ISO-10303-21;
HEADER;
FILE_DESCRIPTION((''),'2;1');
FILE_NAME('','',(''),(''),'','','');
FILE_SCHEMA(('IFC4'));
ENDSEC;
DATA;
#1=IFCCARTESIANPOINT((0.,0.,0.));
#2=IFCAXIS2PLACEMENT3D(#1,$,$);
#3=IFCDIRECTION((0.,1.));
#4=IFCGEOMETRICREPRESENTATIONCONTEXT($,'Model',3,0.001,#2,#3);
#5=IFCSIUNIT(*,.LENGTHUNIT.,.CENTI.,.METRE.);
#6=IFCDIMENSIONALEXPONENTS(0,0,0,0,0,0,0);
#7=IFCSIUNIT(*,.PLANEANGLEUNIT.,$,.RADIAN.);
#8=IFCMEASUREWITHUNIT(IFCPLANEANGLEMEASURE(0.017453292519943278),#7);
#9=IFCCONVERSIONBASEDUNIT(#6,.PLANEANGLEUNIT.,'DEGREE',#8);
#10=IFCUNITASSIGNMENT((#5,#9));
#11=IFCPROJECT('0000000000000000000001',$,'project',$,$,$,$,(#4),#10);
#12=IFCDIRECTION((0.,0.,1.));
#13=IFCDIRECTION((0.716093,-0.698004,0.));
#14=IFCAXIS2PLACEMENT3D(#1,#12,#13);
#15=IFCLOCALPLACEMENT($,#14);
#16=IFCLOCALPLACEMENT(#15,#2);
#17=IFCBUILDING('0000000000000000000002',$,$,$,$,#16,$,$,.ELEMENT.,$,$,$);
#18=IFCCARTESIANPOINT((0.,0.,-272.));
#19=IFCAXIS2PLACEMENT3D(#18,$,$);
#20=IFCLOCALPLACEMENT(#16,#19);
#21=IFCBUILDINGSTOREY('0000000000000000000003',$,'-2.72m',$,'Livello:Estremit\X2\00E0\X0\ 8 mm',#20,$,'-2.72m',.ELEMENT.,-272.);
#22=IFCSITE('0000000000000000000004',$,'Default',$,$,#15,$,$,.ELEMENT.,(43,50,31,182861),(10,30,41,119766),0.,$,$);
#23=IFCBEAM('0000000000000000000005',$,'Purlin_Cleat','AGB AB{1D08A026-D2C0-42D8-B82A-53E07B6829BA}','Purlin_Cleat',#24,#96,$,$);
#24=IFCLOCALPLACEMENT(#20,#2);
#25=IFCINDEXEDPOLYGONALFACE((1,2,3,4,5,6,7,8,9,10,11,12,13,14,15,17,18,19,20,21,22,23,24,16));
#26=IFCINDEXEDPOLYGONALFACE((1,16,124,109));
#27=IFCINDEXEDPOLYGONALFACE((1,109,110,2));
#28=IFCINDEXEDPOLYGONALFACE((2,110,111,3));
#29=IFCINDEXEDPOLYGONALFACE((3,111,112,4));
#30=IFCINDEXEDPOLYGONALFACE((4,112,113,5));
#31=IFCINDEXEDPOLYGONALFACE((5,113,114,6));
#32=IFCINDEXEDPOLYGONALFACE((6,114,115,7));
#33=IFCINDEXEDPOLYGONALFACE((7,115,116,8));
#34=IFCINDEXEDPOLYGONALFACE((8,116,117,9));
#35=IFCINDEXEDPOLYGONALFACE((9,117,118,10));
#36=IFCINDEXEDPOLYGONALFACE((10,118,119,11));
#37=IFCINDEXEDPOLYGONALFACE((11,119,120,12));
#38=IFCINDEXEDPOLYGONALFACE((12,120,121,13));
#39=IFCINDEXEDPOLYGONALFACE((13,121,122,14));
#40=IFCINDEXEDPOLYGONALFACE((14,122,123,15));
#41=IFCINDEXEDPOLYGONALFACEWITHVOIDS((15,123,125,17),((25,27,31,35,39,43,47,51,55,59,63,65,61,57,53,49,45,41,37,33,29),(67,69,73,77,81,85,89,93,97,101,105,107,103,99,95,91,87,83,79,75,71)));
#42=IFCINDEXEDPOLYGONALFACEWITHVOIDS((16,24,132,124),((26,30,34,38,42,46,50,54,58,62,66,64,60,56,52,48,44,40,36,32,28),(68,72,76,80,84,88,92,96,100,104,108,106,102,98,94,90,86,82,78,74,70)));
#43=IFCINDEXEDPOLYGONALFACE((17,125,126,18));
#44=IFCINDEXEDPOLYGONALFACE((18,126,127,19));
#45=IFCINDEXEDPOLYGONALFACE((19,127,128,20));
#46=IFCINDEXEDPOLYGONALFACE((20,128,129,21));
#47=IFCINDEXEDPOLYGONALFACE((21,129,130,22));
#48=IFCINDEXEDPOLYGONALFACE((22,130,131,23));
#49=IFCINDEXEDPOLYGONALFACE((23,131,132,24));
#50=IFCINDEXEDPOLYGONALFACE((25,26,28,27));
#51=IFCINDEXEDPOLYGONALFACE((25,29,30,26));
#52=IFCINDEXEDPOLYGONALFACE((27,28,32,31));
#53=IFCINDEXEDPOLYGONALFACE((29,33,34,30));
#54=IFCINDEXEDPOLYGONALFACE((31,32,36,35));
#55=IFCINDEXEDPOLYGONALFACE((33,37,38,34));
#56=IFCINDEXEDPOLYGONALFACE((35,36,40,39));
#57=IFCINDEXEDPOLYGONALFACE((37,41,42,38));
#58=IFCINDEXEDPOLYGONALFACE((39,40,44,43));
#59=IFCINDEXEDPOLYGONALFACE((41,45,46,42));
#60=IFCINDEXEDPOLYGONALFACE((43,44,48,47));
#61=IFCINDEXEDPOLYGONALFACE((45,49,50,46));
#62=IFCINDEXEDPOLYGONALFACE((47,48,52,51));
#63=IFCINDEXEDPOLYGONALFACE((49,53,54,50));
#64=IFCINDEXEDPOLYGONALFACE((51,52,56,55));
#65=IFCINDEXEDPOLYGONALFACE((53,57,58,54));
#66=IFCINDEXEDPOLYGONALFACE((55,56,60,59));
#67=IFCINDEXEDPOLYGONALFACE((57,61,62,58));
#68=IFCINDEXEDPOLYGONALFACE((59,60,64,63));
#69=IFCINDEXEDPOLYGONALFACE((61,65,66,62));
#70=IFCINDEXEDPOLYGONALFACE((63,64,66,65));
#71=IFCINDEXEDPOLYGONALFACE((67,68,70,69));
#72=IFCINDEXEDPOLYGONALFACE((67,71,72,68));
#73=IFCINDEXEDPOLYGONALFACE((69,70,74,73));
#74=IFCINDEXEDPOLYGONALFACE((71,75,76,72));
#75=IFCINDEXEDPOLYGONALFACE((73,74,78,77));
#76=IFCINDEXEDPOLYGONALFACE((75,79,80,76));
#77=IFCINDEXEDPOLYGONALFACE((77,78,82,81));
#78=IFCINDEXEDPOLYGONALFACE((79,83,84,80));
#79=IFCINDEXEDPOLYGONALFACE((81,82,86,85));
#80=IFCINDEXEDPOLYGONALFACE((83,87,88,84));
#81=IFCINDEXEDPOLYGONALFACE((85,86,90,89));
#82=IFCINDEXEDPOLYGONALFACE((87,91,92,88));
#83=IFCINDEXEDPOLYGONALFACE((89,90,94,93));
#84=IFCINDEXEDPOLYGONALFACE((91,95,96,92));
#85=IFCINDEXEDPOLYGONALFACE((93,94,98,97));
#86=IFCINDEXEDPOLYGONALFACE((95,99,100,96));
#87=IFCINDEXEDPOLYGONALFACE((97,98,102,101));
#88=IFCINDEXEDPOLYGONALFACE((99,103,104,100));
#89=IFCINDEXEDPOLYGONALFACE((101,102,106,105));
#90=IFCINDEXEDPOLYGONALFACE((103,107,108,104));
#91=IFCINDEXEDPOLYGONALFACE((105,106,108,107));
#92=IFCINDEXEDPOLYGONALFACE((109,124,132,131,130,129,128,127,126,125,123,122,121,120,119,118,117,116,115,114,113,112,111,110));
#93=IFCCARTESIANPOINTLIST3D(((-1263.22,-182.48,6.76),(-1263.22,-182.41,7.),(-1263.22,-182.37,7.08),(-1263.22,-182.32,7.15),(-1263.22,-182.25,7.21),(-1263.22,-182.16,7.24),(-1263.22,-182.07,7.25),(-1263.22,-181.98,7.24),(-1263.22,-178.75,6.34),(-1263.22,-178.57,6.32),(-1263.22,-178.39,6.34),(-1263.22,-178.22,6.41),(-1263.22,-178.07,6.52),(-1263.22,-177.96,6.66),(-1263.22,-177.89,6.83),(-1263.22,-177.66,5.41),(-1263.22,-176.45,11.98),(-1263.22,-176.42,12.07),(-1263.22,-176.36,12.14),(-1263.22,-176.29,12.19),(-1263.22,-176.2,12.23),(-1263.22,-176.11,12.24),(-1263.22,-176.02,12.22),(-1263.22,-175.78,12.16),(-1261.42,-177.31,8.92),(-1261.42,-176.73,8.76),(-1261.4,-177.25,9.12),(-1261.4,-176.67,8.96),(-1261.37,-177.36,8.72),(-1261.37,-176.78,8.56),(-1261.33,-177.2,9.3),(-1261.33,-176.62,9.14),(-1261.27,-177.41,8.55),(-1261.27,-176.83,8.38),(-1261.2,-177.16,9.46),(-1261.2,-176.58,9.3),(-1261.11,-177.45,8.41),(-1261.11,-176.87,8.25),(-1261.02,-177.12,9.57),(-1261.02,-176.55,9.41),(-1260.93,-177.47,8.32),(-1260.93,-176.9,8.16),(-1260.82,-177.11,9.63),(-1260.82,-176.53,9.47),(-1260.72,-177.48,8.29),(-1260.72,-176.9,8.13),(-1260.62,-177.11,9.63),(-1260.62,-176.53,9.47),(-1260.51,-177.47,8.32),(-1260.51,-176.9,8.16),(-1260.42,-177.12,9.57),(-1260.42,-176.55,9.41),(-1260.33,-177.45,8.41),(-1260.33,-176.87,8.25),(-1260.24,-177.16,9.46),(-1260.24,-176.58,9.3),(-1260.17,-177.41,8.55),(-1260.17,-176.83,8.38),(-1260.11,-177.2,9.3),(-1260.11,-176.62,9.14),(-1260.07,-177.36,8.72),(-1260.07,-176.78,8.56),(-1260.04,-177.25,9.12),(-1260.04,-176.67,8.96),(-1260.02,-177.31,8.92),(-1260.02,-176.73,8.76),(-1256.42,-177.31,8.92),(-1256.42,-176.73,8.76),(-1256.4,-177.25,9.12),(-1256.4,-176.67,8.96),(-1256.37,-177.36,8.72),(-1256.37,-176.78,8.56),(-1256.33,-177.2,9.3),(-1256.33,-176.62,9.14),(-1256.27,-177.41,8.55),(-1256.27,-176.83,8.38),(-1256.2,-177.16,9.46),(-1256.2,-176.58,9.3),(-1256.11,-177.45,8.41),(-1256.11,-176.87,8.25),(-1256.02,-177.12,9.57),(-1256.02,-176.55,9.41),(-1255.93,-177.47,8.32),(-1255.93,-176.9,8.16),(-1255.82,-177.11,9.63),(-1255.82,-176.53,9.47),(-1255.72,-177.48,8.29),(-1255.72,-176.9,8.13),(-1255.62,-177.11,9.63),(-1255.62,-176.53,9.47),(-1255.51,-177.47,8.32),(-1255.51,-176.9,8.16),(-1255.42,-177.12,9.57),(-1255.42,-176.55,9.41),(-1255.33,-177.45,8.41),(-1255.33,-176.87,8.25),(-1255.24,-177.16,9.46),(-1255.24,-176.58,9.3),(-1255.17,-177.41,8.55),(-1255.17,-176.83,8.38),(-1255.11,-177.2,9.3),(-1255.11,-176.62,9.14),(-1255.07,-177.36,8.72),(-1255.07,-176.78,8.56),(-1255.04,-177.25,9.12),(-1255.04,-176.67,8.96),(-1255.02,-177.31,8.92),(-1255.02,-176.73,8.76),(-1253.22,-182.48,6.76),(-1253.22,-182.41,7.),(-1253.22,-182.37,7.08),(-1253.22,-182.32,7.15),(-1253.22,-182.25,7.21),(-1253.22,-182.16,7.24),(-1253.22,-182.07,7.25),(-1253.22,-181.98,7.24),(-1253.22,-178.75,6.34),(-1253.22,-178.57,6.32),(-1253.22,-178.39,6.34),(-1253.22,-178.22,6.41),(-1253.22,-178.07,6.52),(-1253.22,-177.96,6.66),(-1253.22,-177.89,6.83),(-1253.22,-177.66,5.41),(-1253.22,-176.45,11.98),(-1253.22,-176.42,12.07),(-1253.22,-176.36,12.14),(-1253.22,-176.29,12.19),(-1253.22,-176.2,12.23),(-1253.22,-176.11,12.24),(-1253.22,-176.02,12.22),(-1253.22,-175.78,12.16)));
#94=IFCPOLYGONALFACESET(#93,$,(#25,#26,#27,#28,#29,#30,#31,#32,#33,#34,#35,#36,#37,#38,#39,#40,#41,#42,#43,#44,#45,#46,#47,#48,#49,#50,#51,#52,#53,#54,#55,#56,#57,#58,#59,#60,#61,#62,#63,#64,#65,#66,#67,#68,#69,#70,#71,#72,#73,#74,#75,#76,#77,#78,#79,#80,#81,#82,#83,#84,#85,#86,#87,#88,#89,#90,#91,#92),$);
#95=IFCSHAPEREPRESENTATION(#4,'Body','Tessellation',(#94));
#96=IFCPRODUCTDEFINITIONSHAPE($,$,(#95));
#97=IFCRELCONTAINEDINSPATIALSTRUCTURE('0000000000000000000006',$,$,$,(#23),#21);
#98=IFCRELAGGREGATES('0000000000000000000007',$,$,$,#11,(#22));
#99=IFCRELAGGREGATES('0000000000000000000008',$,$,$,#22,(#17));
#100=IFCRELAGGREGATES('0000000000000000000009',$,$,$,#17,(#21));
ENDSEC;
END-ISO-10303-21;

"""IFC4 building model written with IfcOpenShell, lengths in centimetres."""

from ifc_helpers import new_model, entity, si_unit, converted_unit, direction, frame, frame_2d, origin, place, context, project, spatial, circle, l_section, extrude, element, save


model = new_model("IFC4")

# Units and contexts
model_context = context("Model", 3, precision=0.001, world=origin(), true_north=direction((0.0, 1.0)))
ifc_project = project(units=[si_unit("LENGTHUNIT", "METRE", prefix="CENTI"), converted_unit("PLANEANGLEUNIT", "DEGREE", entity("IfcPlaneAngleMeasure", 0.017453292519943278), si_unit("PLANEANGLEUNIT", "RADIAN"), dimensions=[0, 0, 0, 0, 0, 0, 0])], contexts=[model_context])

# Site, building, storey
site_placement = place(None, frame((0.0, 0.0, 0.0), z_axis=(0.0, 0.0, 1.0), x_axis=(0.716093, -0.698004, 0.0)))
site = spatial("IfcSite", under=ifc_project, at=site_placement, Name="Default", CompositionType="ELEMENT", RefLatitude=(43, 50, 31, 182861), RefLongitude=(10, 30, 41, 119766), RefElevation=0.0)
building_placement = place(site_placement, origin())
building = spatial("IfcBuilding", under=site, at=building_placement, CompositionType="ELEMENT")
storey_placement = place(building_placement, frame((0.0, 0.0, -272.0)))
storey = spatial("IfcBuildingStorey", under=building, at=storey_placement, Name="-2.72m", ObjectType="Livello:Estremità 8 mm", LongName="-2.72m", CompositionType="ELEMENT", Elevation=-272.0)

# Beam, openings
beam_1_placement = place(storey_placement, frame((-1253.22, -178.24, 7.91), z_axis=(1.0, 0.0, 0.0), x_axis=(0.0, 0.268584, 0.963256)))
beam_1 = element("IfcBeam", 1, at=beam_1_placement, inside=storey, Name="Purlin_Cleat", Description="AGB AB{1D08A026-D2C0-42D8-B82A-53E07B6829BA}", ObjectType="Purlin_Cleat", context=model_context, shape_type="SweptSolid", body=[
    extrude(l_section(Depth=5.0, Width=7.0, Thickness=0.6, FilletRadius=0.7, EdgeRadius=0.35, at=frame_2d((1.25, 1.27))), origin(), (0.0, 0.0, -1.0), 10.0),
])
opening_1_placement = place(beam_1_placement, frame((1.27, -0.6, -3.2), z_axis=(0.0, 1.0, 0.0), x_axis=(-1.0, 0.0, 0.0)))
element("IfcOpeningElement", 2, at=opening_1_placement, cuts=beam_1, ObjectType="Opening", context=model_context, shape_type="SweptSolid", body=[
    extrude(circle(Radius=0.7, at=frame_2d((0.0, 0.7), x_axis=(1.0, 0.0))), origin(), (0.0, 0.0, -1.0), 0.7),
])
opening_2_placement = place(beam_1_placement, frame((1.27, -0.6, -8.2), z_axis=(0.0, 1.0, 0.0), x_axis=(-1.0, 0.0, 0.0)))
element("IfcOpeningElement", 3, at=opening_2_placement, cuts=beam_1, ObjectType="Opening", context=model_context, shape_type="SweptSolid", body=[
    extrude(circle(Radius=0.7, at=frame_2d((0.0, 0.7), x_axis=(1.0, 0.0))), origin(), (0.0, 0.0, -1.0), 0.7),
])

save(model, "model.ifc")
